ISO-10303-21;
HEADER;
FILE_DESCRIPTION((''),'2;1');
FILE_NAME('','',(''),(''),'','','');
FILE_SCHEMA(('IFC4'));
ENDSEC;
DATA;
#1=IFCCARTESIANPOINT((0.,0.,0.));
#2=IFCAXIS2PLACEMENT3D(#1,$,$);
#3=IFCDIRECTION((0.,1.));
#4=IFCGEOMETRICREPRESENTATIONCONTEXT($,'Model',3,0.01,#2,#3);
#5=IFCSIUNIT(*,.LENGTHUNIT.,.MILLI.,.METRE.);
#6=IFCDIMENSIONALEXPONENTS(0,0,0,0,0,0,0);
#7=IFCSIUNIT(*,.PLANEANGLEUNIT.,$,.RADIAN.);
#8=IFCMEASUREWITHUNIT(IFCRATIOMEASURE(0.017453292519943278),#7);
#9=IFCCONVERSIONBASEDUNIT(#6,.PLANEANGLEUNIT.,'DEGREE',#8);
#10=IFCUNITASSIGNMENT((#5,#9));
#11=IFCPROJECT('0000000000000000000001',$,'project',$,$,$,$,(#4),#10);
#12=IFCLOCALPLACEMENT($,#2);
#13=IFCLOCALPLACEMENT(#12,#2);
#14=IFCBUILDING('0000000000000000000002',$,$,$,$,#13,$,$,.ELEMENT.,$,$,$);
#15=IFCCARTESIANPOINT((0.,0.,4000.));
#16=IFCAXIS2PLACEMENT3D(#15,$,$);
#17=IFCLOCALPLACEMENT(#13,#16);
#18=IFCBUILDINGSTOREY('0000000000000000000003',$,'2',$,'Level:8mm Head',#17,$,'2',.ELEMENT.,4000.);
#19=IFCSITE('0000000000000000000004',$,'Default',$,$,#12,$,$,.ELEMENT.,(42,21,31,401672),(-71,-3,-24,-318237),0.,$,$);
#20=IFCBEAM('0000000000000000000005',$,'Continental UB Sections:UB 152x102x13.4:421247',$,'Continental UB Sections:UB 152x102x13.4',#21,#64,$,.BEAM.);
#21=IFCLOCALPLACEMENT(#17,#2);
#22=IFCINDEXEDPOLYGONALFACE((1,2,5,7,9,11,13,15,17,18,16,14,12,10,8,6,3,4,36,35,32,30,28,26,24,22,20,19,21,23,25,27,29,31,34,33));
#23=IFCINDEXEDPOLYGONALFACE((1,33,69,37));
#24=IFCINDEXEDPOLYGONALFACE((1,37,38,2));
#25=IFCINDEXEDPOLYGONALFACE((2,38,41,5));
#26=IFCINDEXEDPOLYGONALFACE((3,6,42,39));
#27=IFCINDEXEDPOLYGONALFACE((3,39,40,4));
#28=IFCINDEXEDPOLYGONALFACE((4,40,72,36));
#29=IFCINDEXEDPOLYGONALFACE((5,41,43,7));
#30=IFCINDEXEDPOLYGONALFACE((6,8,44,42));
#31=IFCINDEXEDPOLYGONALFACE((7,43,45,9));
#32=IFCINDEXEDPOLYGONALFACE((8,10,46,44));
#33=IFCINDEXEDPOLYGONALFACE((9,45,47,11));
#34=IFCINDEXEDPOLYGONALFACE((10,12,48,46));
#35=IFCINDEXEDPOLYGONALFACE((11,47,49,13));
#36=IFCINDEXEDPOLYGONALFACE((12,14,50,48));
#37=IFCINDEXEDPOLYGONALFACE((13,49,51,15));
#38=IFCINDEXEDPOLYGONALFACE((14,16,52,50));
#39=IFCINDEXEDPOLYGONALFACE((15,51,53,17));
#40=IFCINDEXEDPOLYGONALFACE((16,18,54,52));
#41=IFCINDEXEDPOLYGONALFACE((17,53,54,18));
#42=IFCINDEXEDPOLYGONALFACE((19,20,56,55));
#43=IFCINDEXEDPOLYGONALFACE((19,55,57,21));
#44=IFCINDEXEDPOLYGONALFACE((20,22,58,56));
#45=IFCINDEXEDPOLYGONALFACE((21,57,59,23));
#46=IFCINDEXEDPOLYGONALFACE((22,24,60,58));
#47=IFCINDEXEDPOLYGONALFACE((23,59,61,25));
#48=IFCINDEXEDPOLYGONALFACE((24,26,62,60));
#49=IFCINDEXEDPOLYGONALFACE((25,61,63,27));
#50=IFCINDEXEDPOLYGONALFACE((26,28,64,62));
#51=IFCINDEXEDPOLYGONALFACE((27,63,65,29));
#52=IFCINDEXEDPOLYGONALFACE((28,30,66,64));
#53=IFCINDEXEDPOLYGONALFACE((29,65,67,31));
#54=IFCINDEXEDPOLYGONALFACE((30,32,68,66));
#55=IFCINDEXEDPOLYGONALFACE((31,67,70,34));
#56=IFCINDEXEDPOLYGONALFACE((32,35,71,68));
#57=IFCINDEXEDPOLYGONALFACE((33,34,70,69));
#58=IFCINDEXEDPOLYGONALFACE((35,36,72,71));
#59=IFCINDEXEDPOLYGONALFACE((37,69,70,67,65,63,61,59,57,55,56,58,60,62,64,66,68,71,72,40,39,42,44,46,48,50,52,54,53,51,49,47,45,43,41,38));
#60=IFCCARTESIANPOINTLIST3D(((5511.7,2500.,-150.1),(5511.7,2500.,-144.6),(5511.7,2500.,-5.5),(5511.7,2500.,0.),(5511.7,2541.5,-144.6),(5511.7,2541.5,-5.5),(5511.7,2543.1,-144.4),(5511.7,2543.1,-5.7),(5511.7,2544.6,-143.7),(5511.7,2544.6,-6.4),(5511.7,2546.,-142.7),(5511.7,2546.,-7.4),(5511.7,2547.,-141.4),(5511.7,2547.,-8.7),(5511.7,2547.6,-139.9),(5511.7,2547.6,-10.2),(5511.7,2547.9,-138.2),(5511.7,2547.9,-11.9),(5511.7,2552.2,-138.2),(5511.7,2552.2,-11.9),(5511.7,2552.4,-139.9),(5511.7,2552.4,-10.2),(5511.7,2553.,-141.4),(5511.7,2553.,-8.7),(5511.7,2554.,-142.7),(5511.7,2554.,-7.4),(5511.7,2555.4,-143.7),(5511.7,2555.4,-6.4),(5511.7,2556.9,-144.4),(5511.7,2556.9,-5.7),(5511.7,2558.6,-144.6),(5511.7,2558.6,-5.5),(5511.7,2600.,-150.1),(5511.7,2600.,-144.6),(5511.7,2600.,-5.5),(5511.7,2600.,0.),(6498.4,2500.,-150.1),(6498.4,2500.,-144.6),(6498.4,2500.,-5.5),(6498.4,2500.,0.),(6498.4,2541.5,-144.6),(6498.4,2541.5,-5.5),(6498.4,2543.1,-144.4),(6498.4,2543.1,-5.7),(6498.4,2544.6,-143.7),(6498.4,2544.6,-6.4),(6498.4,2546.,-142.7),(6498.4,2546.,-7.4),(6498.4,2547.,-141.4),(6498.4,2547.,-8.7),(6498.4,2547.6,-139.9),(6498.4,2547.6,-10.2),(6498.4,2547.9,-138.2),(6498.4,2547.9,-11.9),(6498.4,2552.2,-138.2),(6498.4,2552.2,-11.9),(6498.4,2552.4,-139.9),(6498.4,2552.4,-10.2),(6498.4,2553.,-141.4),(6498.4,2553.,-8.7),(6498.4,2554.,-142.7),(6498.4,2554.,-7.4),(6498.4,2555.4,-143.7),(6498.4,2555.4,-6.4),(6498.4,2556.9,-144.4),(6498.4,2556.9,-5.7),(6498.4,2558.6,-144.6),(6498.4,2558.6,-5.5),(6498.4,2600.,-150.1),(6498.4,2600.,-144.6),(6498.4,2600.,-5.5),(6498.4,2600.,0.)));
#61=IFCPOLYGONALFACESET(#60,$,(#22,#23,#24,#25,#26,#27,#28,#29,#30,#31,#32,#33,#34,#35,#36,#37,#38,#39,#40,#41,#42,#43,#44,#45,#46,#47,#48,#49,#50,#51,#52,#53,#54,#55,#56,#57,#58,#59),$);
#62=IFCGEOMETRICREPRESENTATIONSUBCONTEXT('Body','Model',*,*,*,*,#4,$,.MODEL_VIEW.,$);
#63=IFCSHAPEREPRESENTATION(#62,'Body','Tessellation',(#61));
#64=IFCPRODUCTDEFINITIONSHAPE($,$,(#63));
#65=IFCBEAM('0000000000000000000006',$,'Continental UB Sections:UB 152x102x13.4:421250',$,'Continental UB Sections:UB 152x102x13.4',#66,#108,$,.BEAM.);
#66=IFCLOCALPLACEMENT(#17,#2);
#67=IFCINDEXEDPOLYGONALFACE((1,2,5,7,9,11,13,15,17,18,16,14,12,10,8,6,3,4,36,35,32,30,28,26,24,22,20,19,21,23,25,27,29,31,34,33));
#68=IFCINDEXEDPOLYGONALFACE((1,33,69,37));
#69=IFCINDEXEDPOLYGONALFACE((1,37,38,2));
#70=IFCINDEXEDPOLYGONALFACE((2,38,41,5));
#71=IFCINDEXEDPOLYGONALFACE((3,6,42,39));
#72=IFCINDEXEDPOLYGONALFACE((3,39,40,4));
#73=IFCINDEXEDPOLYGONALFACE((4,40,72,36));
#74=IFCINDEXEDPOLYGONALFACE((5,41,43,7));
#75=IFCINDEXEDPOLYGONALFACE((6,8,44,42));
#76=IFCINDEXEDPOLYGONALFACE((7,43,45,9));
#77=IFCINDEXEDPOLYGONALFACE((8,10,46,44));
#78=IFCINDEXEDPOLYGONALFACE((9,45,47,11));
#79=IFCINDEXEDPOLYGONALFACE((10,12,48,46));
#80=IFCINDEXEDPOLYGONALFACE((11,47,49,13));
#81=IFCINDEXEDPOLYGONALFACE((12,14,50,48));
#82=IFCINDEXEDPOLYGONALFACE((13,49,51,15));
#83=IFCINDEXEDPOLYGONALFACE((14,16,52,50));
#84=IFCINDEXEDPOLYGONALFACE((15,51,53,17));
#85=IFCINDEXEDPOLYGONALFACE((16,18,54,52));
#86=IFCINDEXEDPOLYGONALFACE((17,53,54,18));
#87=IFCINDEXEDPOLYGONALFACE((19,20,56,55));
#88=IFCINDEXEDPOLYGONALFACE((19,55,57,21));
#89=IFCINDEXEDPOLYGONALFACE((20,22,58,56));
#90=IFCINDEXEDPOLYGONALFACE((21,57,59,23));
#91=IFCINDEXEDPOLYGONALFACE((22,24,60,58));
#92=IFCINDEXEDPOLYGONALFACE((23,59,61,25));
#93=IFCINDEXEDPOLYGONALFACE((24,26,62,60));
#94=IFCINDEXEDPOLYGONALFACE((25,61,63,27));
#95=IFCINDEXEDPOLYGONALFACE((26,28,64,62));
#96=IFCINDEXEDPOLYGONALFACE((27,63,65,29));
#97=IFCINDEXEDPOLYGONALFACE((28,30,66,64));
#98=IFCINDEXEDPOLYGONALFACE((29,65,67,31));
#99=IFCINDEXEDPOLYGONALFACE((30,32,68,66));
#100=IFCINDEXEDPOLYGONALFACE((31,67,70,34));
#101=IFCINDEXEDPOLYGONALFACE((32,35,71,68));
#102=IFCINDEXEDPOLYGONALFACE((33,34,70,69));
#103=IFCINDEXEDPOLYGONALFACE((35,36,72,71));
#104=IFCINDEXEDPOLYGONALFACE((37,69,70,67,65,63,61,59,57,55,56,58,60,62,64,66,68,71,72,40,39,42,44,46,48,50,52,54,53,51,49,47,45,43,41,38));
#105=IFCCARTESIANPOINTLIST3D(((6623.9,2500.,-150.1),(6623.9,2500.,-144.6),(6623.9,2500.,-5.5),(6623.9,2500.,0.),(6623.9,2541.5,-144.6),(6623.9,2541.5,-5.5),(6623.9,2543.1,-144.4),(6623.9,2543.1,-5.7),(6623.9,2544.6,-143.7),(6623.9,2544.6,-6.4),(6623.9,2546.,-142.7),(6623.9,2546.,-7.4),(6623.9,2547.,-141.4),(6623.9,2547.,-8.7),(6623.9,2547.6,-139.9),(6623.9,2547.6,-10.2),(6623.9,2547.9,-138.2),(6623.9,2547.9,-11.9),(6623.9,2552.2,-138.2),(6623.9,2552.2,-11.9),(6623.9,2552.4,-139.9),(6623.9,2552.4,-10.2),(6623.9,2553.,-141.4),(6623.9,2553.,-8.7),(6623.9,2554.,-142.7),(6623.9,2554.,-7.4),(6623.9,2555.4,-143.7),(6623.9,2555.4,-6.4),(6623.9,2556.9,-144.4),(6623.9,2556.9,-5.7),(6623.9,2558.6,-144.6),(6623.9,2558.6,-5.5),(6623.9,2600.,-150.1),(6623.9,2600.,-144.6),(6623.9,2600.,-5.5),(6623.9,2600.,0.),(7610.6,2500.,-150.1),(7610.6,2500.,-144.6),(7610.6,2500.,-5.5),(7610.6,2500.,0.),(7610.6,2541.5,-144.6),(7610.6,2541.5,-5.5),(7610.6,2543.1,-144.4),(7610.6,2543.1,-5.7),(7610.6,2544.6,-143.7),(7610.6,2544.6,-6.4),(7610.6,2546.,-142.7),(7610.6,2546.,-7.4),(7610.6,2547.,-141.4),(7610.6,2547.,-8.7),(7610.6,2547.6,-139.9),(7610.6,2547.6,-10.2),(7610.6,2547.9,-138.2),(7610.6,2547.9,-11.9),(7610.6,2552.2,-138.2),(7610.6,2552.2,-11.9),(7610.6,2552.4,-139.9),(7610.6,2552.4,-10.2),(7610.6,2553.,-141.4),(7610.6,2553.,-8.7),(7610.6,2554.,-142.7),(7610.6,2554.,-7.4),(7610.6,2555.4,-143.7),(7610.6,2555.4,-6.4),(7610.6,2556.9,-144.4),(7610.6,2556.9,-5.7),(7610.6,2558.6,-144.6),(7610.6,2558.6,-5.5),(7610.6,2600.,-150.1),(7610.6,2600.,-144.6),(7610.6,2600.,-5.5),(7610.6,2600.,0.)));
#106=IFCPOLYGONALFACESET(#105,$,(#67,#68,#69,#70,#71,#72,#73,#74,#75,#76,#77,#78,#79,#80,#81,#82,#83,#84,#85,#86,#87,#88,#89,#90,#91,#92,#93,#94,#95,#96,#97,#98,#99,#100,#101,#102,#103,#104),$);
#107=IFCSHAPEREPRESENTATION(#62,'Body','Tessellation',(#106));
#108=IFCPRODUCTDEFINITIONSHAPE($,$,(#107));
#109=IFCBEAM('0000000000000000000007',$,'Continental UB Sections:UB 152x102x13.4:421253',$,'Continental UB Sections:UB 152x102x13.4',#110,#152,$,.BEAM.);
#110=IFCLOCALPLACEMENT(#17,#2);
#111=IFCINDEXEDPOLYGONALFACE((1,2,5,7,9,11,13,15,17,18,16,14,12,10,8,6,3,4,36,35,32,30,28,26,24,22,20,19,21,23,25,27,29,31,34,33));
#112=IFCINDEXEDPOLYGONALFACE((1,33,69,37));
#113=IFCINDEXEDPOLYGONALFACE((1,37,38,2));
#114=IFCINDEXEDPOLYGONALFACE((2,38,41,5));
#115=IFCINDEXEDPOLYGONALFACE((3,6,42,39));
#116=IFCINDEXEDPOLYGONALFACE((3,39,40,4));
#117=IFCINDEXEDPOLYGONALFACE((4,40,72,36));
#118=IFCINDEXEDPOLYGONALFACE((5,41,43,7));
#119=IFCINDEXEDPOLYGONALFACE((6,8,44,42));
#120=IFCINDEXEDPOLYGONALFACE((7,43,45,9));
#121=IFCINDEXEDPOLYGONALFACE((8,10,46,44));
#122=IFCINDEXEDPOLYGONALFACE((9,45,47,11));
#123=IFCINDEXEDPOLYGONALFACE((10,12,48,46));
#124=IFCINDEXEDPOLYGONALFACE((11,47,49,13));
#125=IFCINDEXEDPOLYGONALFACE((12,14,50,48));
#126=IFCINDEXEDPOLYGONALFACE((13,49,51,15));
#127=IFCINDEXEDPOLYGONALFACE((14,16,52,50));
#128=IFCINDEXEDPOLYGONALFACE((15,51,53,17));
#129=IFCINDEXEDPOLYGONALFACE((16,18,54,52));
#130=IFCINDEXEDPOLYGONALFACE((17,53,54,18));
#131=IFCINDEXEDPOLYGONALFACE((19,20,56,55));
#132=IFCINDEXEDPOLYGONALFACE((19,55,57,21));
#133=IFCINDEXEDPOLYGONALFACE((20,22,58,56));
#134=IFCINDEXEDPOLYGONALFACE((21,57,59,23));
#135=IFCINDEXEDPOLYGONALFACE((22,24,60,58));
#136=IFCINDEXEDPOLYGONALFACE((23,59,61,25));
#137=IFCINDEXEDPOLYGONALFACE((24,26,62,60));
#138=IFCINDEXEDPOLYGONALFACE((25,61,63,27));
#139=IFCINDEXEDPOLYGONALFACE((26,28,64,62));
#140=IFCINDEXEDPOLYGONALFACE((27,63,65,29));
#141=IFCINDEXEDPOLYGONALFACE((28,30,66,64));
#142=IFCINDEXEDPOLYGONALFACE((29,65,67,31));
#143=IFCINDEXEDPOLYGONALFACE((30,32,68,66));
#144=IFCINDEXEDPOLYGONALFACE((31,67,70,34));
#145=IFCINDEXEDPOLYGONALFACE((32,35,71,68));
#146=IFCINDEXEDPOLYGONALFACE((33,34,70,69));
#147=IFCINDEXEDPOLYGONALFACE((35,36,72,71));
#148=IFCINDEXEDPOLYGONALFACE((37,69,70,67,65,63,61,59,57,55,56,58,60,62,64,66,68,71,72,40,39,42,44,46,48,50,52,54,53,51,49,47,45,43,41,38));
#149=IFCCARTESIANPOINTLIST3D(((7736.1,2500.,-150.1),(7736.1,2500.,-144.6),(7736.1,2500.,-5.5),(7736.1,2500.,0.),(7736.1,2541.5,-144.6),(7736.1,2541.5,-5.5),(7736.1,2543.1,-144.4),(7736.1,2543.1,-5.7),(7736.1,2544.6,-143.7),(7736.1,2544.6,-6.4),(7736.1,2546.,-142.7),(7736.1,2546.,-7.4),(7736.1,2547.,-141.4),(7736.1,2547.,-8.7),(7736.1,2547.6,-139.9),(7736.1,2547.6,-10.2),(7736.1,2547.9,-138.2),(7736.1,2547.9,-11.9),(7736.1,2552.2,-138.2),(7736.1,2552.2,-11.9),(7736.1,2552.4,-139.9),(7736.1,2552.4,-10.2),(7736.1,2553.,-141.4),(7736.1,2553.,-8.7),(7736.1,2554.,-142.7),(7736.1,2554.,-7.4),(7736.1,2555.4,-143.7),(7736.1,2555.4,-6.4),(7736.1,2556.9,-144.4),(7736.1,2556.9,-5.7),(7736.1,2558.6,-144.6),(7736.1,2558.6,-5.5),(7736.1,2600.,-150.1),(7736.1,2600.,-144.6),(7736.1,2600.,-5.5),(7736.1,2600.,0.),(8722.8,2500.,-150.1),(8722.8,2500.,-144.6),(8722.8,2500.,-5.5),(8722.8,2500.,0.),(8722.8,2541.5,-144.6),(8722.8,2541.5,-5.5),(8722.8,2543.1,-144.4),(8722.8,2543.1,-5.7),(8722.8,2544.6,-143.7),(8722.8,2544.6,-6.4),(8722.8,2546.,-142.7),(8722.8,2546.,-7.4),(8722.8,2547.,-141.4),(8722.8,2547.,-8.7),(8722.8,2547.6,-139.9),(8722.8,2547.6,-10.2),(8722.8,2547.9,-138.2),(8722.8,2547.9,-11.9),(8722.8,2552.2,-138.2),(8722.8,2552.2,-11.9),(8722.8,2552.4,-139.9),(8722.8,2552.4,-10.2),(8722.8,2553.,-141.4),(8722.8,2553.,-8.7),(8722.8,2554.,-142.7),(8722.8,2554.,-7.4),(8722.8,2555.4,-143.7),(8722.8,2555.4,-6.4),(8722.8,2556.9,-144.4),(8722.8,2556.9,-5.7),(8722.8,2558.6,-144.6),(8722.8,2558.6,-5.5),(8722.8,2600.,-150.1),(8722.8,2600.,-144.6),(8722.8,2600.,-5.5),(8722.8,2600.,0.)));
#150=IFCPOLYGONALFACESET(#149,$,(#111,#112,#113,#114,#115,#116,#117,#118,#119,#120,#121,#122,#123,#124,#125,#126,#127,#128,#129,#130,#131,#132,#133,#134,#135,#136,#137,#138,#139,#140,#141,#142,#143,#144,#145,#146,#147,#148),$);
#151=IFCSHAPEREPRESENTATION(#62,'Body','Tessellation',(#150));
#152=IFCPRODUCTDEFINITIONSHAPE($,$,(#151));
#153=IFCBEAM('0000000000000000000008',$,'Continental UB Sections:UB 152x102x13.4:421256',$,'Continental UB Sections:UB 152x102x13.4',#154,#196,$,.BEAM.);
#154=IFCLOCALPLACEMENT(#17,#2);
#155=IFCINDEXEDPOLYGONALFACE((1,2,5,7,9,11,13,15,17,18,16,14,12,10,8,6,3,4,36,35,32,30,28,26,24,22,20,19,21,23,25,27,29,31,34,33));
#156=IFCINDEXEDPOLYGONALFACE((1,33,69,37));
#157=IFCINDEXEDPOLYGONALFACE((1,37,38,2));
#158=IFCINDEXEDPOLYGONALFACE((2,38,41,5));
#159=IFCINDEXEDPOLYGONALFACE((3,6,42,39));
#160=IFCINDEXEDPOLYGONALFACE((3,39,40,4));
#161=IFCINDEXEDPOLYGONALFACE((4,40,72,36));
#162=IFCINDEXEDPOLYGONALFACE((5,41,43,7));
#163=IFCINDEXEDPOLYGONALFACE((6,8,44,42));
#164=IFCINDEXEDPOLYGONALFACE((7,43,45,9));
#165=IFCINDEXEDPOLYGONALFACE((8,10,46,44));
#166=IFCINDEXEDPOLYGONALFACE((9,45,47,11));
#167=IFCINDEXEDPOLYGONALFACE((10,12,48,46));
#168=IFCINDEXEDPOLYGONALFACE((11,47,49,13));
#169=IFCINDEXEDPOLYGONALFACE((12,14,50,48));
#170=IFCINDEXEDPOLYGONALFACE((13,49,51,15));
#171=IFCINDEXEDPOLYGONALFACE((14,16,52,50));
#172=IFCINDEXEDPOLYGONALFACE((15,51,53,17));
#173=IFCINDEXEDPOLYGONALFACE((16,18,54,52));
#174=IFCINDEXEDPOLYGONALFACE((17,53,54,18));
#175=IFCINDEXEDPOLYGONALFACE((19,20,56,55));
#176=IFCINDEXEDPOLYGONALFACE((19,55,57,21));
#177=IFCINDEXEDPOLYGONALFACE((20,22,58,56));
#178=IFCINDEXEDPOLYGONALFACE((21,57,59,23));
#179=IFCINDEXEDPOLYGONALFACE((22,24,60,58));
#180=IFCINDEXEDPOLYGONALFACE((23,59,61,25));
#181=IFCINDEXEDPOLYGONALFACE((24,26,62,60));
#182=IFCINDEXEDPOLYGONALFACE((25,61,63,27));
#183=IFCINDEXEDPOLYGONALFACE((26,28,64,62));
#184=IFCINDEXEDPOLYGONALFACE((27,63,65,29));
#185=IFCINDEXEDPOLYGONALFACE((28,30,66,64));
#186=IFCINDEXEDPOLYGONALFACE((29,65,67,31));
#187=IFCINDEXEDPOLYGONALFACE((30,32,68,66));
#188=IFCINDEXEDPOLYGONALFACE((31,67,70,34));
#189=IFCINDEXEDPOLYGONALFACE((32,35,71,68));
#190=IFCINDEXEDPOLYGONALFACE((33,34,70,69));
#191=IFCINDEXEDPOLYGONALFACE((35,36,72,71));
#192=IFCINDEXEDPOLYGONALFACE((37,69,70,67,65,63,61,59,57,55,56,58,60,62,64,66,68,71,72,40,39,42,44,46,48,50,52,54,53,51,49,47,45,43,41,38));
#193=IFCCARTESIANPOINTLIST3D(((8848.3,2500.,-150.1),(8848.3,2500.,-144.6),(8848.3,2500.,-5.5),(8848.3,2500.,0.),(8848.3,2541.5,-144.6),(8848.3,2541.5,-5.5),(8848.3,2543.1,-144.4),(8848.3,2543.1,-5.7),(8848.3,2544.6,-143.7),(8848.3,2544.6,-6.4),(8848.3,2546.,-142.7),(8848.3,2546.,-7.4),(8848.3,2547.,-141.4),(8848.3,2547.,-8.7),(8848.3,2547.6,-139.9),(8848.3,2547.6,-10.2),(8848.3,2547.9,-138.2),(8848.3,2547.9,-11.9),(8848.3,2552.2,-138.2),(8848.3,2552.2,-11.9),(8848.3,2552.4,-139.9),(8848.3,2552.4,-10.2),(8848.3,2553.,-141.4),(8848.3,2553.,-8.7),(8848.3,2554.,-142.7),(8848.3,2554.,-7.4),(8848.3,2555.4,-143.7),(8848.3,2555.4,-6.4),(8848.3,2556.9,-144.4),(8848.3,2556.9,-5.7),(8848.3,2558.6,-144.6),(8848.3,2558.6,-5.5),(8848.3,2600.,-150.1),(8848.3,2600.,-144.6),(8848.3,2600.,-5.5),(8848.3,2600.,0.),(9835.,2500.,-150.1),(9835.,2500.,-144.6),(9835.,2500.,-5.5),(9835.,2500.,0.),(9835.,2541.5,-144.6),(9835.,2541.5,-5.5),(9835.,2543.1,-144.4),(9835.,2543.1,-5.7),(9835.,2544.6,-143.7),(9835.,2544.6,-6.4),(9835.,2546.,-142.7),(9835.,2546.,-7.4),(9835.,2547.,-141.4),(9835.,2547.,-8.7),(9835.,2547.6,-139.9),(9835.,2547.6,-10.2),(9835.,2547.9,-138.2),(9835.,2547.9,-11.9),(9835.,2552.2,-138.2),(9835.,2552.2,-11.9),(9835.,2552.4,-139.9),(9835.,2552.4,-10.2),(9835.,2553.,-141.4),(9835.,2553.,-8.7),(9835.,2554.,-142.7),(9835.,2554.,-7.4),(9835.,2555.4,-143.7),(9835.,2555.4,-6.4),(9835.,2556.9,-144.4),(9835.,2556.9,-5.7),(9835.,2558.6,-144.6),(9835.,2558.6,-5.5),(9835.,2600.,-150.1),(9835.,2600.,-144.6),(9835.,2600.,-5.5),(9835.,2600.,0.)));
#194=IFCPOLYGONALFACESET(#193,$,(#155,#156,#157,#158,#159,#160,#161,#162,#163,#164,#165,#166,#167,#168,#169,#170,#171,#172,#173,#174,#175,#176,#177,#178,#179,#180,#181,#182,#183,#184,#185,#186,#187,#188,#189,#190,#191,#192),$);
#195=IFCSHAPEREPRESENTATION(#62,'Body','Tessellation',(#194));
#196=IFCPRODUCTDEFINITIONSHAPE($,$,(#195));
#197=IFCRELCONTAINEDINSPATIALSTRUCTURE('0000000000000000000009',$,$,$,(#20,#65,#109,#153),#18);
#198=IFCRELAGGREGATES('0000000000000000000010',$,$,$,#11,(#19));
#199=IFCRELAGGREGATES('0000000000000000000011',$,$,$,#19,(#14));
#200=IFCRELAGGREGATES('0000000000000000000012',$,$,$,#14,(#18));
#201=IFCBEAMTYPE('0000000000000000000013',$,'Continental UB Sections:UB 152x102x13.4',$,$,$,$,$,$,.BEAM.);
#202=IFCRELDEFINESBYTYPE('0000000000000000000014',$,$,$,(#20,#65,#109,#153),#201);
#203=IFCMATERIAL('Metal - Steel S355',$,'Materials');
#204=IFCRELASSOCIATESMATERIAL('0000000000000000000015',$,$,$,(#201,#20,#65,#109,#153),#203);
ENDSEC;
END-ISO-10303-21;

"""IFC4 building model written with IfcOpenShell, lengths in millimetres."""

from ifc_helpers import new_model, entity, si_unit, converted_unit, direction, frame, origin, place, context, subcontext, project, spatial, line, arc, indexed_curve, outline, extrude, source, transform, mapped, material, type_object, type_shapes, element, save


model = new_model("IFC4")

# Units and contexts
model_context = context("Model", 3, precision=0.01, world=origin(), true_north=direction((0.0, 1.0)))
body_context = subcontext(model_context, "Body", "Model", "MODEL_VIEW")
ifc_project = project(units=[si_unit("LENGTHUNIT", "METRE", prefix="MILLI"), converted_unit("PLANEANGLEUNIT", "DEGREE", entity("IfcRatioMeasure", 0.017453292519943278), si_unit("PLANEANGLEUNIT", "RADIAN"), dimensions=[0, 0, 0, 0, 0, 0, 0])], contexts=[model_context])

# Site, building, storey
site_placement = place(None, origin())
site = spatial("IfcSite", under=ifc_project, at=site_placement, Name="Default", CompositionType="ELEMENT", RefLatitude=(42, 21, 31, 401672), RefLongitude=(-71, -3, -24, -318237), RefElevation=0.0)
building_placement = place(site_placement, origin())
building = spatial("IfcBuilding", under=site, at=building_placement, CompositionType="ELEMENT")
storey_placement = place(building_placement, frame((0.0, 0.0, 4000.0)))
storey = spatial("IfcBuildingStorey", under=building, at=storey_placement, Name="2", ObjectType="Level:8mm Head", LongName="2", CompositionType="ELEMENT", Elevation=4000.0)

# Beams
ifc_material = material(Name="Metal - Steel S355", Category="Materials")
beam_type_1 = type_object("IfcBeamType", Name="Continental UB Sections:UB 152x102x13.4", PredefinedType="BEAM", material=ifc_material)
shared_shape_1 = source(origin(), body_context, "Body", "SweptSolid", [
    extrude(outline(indexed_curve([(-75.0, -50.1), (-69.6, -50.1), (-69.6, -8.5), (-67.7, -4.0), (-63.2, -2.1), (63.1, -2.1), (67.7, -4.0), (69.5, -8.5), (69.5, -50.1), (75.1, -50.1), (75.1, 50.1), (69.5, 50.1), (69.5, 8.6), (67.7, 4.0), (63.1, 2.2), (-63.2, 2.2), (-67.7, 4.0), (-69.6, 8.6), (-69.6, 50.0), (-75.0, 50.0)], segments=[line(1, 2, 3), arc(3, 4, 5), line(5, 6), arc(6, 7, 8), line(8, 9, 10, 11, 12, 13), arc(13, 14, 15), line(15, 16), arc(16, 17, 18), line(18, 19, 20, 1)], self_intersect=False)), frame((-493.3, 0.0, 0.0), z_axis=(1.0, 0.0, 0.0), x_axis=(0.0, 0.0, -1.0)), (0.0, 0.0, 1.0), 986.7),
])
type_shapes(beam_type_1, [shared_shape_1])
for number, where, name in (
    (1, (6005.0, 2550.0, -75.1), "Continental UB Sections:UB 152x102x13.4:421247"),
    (2, (7117.2, 2550.0, -75.1), "Continental UB Sections:UB 152x102x13.4:421250"),
    (3, (8229.4, 2550.0, -75.1), "Continental UB Sections:UB 152x102x13.4:421253"),
    (4, (9341.7, 2550.0, -75.1), "Continental UB Sections:UB 152x102x13.4:421256"),
):
    element("IfcBeam", number, at=place(storey_placement, frame(where)), inside=storey, type_object=beam_type_1, material=ifc_material, Name=name, ObjectType="Continental UB Sections:UB 152x102x13.4", PredefinedType="BEAM", context=body_context, shape_type="MappedRepresentation", body=[
        mapped(shared_shape_1, transform((0.0, 0.0, 0.0), scale=1.0)),
    ])

save(model, "model.ifc")
